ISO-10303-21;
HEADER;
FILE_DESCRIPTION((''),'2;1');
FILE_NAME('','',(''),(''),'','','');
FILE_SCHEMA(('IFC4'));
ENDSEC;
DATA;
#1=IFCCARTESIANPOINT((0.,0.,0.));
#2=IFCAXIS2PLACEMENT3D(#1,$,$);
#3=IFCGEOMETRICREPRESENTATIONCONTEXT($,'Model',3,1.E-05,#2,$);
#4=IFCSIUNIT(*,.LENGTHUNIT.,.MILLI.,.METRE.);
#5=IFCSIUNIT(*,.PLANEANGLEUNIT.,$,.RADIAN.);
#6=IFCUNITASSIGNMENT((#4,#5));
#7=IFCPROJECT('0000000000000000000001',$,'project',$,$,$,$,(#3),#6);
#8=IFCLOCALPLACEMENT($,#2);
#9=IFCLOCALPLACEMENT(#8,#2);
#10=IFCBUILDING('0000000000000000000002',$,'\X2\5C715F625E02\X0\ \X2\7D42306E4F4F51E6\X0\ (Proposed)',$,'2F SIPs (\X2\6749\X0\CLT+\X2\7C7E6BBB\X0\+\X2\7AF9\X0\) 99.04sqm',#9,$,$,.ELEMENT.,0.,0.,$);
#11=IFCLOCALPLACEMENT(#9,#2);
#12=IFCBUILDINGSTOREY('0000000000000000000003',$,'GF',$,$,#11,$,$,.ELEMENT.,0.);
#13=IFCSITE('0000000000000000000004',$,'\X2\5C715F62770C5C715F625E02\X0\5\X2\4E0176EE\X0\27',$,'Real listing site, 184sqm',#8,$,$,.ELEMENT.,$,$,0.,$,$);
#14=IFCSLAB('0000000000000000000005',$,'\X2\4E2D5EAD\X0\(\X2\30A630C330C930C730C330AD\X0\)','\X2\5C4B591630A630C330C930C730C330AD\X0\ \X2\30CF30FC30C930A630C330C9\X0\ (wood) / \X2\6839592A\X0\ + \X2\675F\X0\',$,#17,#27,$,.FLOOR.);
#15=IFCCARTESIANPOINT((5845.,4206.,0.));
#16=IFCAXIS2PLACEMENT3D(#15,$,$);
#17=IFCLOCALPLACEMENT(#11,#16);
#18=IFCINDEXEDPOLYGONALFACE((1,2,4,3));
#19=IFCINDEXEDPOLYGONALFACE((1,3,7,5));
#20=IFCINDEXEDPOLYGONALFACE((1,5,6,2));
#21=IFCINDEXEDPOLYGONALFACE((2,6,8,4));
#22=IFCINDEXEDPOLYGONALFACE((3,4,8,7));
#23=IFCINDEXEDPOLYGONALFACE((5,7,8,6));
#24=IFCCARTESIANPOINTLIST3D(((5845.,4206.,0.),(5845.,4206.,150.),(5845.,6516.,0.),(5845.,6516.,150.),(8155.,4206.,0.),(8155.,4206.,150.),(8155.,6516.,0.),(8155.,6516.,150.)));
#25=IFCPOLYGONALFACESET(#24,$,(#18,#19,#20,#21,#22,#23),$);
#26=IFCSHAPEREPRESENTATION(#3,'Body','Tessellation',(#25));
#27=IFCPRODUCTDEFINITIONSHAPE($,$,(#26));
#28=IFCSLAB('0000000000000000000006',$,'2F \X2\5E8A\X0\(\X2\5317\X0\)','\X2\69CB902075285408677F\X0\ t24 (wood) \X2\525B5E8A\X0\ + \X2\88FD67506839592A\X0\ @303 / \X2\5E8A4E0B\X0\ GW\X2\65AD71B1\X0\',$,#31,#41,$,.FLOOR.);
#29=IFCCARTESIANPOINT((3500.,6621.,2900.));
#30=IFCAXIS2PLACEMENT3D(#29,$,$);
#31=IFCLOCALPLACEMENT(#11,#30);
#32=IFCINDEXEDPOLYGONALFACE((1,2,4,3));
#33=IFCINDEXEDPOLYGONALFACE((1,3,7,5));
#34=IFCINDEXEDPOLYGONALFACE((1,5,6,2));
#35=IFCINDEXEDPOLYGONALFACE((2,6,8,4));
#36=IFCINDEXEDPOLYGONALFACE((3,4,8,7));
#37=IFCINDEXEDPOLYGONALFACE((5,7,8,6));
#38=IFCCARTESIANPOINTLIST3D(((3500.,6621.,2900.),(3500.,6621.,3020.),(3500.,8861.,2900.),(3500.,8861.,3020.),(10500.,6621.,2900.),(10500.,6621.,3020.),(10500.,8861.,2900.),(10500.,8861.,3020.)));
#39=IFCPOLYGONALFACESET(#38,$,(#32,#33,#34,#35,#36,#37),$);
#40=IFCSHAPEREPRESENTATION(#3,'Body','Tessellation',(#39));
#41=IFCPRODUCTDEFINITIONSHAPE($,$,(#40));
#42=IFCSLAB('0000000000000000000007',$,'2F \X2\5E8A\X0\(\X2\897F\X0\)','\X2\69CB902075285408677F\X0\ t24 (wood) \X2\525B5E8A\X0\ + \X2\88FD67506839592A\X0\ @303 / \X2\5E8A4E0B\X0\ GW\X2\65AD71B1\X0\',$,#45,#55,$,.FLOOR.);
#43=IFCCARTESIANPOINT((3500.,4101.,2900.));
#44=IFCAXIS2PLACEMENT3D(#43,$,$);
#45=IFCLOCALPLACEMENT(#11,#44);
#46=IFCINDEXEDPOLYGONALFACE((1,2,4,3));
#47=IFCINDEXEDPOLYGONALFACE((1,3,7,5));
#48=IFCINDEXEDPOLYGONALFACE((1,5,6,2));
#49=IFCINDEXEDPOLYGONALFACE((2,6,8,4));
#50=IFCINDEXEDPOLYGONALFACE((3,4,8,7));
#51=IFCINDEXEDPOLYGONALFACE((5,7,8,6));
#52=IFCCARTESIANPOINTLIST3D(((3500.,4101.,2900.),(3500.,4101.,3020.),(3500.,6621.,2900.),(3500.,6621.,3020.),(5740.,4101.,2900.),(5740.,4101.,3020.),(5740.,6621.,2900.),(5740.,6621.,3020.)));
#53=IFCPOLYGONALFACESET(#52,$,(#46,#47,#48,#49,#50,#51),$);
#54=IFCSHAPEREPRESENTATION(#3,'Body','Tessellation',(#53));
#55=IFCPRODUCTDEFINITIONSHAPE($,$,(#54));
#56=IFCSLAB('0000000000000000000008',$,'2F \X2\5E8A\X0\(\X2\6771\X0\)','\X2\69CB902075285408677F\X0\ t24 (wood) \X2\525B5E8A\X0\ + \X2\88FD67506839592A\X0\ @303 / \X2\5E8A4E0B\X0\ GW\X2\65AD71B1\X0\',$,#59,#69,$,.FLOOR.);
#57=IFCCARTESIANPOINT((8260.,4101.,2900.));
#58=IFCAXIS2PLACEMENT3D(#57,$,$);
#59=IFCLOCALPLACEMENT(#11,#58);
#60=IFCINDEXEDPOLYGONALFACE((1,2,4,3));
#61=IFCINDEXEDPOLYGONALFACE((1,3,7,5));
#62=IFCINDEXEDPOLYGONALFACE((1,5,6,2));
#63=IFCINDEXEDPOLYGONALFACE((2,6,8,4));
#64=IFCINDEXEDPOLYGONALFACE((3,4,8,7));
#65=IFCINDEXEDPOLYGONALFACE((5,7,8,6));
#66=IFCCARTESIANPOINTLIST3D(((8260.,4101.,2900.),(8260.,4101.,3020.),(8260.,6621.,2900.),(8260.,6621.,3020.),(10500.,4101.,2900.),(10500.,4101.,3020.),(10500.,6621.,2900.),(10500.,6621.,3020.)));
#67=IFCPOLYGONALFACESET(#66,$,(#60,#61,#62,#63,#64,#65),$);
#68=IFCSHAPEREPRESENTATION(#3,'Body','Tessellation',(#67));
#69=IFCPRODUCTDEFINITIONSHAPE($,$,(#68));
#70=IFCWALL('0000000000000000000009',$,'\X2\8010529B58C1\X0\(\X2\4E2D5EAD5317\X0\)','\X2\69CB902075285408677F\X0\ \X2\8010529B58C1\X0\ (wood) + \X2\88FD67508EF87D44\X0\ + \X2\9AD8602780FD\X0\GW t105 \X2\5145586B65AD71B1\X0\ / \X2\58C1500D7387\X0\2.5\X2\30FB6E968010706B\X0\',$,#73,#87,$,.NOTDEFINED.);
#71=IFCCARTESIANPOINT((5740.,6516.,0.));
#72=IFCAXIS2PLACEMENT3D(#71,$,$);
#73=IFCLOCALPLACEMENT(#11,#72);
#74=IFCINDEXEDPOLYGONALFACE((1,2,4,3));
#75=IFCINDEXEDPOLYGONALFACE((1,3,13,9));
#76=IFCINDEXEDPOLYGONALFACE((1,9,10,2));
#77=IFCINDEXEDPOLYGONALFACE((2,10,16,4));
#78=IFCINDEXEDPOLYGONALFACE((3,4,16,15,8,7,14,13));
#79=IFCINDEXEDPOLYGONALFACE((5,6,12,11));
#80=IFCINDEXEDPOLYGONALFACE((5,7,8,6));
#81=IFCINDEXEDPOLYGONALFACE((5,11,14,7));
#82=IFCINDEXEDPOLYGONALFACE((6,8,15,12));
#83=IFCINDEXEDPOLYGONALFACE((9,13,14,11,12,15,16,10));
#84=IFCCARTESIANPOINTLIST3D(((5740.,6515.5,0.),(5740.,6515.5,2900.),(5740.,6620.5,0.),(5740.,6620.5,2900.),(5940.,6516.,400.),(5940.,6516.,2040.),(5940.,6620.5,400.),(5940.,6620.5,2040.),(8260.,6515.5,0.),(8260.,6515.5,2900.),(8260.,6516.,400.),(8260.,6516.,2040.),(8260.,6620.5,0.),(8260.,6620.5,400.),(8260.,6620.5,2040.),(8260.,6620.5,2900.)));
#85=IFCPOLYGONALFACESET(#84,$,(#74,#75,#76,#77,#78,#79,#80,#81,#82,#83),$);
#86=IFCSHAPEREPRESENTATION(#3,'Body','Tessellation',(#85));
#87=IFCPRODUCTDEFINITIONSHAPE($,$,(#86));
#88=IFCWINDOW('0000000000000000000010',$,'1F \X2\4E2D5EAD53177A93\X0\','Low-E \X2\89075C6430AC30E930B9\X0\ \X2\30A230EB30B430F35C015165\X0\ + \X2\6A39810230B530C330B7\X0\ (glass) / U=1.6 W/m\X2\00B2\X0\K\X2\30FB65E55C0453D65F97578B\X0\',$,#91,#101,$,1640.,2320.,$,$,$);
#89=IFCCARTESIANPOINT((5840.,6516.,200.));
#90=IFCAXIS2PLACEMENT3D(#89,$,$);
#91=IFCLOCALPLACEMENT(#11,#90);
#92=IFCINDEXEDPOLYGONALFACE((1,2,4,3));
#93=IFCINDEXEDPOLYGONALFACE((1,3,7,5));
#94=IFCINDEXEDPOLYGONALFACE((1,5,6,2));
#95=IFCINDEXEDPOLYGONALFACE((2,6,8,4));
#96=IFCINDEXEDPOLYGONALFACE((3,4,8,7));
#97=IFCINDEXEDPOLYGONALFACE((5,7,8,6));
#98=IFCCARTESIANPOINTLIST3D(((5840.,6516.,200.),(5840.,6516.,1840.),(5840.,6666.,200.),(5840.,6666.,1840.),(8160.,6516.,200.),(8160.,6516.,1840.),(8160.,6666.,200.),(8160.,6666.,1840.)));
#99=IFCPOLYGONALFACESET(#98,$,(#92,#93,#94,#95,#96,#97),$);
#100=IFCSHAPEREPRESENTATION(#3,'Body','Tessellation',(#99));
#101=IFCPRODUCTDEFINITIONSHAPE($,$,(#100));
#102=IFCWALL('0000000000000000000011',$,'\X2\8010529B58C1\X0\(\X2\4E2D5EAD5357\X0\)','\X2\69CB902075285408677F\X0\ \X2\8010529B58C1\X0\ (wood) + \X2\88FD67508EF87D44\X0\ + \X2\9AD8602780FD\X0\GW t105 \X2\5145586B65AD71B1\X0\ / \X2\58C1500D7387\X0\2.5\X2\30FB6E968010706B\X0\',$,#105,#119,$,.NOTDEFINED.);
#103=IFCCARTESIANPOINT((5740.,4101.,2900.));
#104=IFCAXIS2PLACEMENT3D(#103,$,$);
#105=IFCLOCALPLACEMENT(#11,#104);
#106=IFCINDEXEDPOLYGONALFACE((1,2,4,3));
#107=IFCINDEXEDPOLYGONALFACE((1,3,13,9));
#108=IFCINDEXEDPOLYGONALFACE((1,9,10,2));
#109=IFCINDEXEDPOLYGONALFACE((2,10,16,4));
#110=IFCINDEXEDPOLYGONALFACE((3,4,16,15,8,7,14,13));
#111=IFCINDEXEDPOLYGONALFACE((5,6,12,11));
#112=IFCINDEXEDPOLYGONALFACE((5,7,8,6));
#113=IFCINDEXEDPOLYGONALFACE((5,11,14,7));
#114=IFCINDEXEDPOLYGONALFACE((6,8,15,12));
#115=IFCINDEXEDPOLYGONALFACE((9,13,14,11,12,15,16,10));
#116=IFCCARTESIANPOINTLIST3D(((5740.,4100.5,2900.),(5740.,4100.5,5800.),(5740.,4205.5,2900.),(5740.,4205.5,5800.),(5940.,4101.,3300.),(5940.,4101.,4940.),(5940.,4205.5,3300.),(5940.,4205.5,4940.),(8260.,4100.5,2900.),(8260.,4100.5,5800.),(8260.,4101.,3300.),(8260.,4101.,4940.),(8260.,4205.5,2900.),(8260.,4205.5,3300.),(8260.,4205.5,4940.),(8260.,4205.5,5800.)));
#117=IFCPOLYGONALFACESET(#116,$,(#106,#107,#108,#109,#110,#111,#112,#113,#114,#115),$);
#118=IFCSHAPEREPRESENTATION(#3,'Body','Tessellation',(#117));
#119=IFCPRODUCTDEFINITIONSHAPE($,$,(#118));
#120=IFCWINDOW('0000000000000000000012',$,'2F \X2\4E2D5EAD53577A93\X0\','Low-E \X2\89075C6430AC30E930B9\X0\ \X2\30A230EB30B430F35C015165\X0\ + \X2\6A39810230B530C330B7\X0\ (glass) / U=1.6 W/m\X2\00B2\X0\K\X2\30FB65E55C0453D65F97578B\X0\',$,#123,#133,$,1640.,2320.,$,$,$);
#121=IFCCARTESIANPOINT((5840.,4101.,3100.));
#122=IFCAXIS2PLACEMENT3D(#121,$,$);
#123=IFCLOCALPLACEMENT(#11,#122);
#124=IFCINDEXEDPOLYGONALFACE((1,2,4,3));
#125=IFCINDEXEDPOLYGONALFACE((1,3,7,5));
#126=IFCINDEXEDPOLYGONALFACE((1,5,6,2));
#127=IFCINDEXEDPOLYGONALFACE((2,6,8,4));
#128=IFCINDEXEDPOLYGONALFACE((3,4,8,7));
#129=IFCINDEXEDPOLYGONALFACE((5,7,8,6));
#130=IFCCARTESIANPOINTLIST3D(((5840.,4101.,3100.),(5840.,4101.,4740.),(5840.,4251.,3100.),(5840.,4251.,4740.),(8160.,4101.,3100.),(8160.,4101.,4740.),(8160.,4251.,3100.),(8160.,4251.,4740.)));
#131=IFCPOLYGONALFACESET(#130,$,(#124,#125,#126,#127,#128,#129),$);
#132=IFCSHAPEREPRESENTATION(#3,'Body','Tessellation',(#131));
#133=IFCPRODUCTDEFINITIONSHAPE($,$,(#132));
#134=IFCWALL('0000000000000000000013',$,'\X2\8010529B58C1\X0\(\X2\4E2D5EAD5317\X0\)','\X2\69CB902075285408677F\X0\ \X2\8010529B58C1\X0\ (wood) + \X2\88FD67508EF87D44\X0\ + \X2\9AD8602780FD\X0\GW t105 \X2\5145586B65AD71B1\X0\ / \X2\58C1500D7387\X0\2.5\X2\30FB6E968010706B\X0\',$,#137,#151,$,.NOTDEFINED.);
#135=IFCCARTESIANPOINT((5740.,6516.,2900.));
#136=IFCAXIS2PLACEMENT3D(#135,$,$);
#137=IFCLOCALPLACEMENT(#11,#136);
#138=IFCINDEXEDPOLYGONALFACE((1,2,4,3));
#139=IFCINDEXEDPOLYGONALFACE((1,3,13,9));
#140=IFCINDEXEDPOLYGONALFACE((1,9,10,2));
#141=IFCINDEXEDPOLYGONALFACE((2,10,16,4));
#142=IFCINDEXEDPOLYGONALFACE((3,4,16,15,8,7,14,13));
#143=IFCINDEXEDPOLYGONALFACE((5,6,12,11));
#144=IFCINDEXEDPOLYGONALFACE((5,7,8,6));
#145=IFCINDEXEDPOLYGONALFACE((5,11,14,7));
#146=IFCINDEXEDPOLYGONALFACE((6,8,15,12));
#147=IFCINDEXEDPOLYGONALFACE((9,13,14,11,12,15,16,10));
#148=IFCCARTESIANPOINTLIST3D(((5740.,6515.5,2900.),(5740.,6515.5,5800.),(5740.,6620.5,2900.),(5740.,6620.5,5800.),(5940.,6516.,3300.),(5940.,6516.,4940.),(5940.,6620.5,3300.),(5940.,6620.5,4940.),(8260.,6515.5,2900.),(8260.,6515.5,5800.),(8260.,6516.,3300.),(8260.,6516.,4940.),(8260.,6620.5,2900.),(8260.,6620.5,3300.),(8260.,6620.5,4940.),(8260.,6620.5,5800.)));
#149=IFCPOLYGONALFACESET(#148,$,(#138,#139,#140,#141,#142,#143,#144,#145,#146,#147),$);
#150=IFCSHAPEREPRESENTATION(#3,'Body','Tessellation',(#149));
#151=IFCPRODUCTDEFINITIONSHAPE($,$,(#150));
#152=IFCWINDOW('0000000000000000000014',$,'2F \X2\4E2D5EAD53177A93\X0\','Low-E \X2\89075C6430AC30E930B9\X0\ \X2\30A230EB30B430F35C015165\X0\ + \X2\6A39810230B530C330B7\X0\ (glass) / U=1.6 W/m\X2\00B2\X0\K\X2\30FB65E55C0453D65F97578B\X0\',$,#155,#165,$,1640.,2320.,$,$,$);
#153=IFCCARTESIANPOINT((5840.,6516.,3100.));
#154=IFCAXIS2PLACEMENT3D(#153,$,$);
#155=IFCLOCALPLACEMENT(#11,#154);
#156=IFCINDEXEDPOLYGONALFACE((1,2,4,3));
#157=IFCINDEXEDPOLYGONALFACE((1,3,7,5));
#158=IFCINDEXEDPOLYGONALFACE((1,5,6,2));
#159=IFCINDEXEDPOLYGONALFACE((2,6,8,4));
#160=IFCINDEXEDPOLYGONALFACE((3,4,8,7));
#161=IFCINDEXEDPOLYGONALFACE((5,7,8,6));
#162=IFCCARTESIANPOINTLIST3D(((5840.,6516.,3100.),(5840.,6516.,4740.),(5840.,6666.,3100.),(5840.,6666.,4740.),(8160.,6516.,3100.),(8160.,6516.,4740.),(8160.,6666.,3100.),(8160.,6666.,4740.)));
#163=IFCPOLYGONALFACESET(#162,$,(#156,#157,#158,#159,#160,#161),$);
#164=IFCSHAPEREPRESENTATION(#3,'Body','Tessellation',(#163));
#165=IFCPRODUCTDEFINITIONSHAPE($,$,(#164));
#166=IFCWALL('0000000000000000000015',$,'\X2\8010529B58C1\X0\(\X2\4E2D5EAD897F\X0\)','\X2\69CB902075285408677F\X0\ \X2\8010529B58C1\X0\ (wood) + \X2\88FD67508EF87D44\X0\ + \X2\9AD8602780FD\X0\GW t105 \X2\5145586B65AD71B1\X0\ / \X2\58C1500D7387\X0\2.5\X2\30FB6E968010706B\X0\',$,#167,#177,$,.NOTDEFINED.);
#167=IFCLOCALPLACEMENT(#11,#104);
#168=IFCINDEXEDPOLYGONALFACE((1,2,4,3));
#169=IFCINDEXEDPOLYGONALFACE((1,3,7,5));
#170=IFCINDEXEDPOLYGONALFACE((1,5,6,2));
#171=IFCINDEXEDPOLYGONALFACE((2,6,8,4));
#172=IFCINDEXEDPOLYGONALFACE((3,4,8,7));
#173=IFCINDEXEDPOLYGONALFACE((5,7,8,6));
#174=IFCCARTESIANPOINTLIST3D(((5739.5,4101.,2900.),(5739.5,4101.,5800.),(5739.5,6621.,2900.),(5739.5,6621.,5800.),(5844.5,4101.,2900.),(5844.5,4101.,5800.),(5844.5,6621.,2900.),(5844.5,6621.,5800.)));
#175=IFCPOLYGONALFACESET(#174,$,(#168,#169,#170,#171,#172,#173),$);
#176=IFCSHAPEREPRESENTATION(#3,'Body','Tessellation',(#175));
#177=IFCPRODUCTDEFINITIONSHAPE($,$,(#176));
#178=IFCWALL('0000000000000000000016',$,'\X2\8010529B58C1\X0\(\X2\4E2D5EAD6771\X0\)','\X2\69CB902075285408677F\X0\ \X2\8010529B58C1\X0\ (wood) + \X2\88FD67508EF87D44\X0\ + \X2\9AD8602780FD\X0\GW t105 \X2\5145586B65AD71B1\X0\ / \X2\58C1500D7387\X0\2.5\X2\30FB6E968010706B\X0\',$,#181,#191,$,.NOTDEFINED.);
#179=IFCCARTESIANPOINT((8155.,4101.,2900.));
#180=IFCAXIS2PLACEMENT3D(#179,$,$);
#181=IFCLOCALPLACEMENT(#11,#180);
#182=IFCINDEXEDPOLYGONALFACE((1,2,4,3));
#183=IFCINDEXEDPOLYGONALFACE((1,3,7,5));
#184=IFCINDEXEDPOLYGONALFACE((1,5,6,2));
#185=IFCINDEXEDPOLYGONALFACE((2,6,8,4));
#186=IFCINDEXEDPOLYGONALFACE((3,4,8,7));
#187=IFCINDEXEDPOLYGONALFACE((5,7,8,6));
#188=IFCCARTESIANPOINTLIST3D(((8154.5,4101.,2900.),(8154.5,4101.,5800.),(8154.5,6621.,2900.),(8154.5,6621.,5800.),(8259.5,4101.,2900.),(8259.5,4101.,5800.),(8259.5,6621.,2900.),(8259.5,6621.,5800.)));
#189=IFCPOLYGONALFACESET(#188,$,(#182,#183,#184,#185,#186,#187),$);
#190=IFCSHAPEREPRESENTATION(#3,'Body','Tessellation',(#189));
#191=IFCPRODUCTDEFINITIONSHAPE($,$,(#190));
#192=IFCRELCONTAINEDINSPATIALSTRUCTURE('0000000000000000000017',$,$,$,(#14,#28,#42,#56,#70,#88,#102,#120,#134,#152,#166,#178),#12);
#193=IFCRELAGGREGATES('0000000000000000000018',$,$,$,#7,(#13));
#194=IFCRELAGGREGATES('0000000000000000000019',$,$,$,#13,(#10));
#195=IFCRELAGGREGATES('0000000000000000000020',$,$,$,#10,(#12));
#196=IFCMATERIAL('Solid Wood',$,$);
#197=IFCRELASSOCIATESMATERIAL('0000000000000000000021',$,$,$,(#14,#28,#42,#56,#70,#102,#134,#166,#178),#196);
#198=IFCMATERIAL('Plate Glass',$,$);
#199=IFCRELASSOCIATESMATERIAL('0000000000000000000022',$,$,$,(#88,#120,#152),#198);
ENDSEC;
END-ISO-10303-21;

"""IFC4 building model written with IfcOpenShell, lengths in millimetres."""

from ifc_helpers import new_model, si_unit, frame, frame_2d, origin, place, context, project, spatial, rectangle, extrude, material, element, fill, save


model = new_model("IFC4")

# Units and contexts
model_context = context("Model", 3, precision=1e-05, world=origin())
ifc_project = project(units=[si_unit("LENGTHUNIT", "METRE", prefix="MILLI"), si_unit("PLANEANGLEUNIT", "RADIAN")], contexts=[model_context])

# Site, building, storey
site_placement = place(None, origin())
site = spatial("IfcSite", under=ifc_project, at=site_placement, Name="山形県山形市5丁目27", ObjectType="Real listing site, 184sqm", CompositionType="ELEMENT", RefElevation=0.0)
building_placement = place(site_placement, origin())
building = spatial("IfcBuilding", under=site, at=building_placement, Name="山形市 終の住処 (Proposed)", ObjectType="2F SIPs (杉CLT+籾殻+竹) 99.04sqm", CompositionType="ELEMENT", ElevationOfRefHeight=0.0, ElevationOfTerrain=0.0)
storey_placement = place(building_placement, origin())
storey = spatial("IfcBuildingStorey", under=building, at=storey_placement, Name="GF", CompositionType="ELEMENT", Elevation=0.0)

# Slabs
ifc_material_1 = material(Name="Solid Wood")
slab_1_placement = place(storey_placement, frame((5845.0, 4206.0, 0.0)))
element("IfcSlab", 1, at=slab_1_placement, inside=storey, material=ifc_material_1, Name="中庭(ウッドデッキ)", Description="屋外ウッドデッキ ハードウッド (wood) / 根太 + 束", PredefinedType="FLOOR", context=model_context, shape_type="SweptSolid", body=[
    extrude(rectangle(XDim=2310.0, YDim=2310.0, at=frame_2d((1155.0, 1155.0))), frame((5845.0, 4206.0, 0.0)), (0.0, 0.0, 1.0), 150.0),
])
slab_2_placement = place(storey_placement, frame((3500.0, 6621.0, 2900.0)))
element("IfcSlab", 2, at=slab_2_placement, inside=storey, material=ifc_material_1, Name="2F 床(北)", Description="構造用合板 t24 (wood) 剛床 + 製材根太 @303 / 床下 GW断熱", PredefinedType="FLOOR", context=model_context, shape_type="SweptSolid", body=[
    extrude(rectangle(XDim=7000.0, YDim=2240.0, at=frame_2d((3500.0, 1120.0))), frame((3500.0, 6621.0, 2900.0)), (0.0, 0.0, 1.0), 120.0),
])
slab_3_placement = place(storey_placement, frame((3500.0, 4101.0, 2900.0)))
element("IfcSlab", 3, at=slab_3_placement, inside=storey, material=ifc_material_1, Name="2F 床(西)", Description="構造用合板 t24 (wood) 剛床 + 製材根太 @303 / 床下 GW断熱", PredefinedType="FLOOR", context=model_context, shape_type="SweptSolid", body=[
    extrude(rectangle(XDim=2240.0, YDim=2520.0, at=frame_2d((1120.0, 1260.0))), frame((3500.0, 4101.0, 2900.0)), (0.0, 0.0, 1.0), 120.0),
])
slab_4_placement = place(storey_placement, frame((8260.0, 4101.0, 2900.0)))
element("IfcSlab", 4, at=slab_4_placement, inside=storey, material=ifc_material_1, Name="2F 床(東)", Description="構造用合板 t24 (wood) 剛床 + 製材根太 @303 / 床下 GW断熱", PredefinedType="FLOOR", context=model_context, shape_type="SweptSolid", body=[
    extrude(rectangle(XDim=2240.0, YDim=2520.0, at=frame_2d((1120.0, 1260.0))), frame((8260.0, 4101.0, 2900.0)), (0.0, 0.0, 1.0), 120.0),
])

# Wall, opening, window
wall_1_placement = place(storey_placement, frame((5740.0, 6516.0, 0.0)))
wall_1 = element("IfcWall", 5, at=wall_1_placement, inside=storey, material=ifc_material_1, Name="耐力壁(中庭北)", Description="構造用合板 耐力壁 (wood) + 製材軸組 + 高性能GW t105 充填断熱 / 壁倍率2.5・準耐火", PredefinedType="NOTDEFINED", context=model_context, shape_type="SweptSolid", body=[
    extrude(rectangle(XDim=2520.0, YDim=105.0, at=frame_2d((1260.0, 52.0))), frame((5740.0, 6516.0, 0.0)), (0.0, 0.0, 1.0), 2900.0),
])
opening_1_placement = place(storey_placement, frame((5840.0, 6516.0, 200.0)))
opening_1 = element("IfcOpeningElement", 6, at=opening_1_placement, cuts=wall_1, PredefinedType="NOTDEFINED", context=model_context, shape_type="SweptSolid", body=[
    extrude(rectangle(XDim=2320.0, YDim=150.0, at=frame_2d((1160.0, 75.0))), frame((5840.0, 6516.0, 200.0)), (0.0, 0.0, 1.0), 1640.0),
])
ifc_material_2 = material(Name="Plate Glass")
window_1_placement = place(storey_placement, frame((5840.0, 6516.0, 200.0)))
window_1 = element("IfcWindow", 7, at=window_1_placement, inside=storey, material=ifc_material_2, Name="1F 中庭北窓", Description="Low-E 複層ガラス アルゴン封入 + 樹脂サッシ (glass) / U=1.6 W/m²K・日射取得型", OverallHeight=1640.0, OverallWidth=2320.0, context=model_context, shape_type="SweptSolid", body=[
    extrude(rectangle(XDim=2320.0, YDim=150.0, at=frame_2d((1160.0, 75.0))), frame((5840.0, 6516.0, 200.0)), (0.0, 0.0, 1.0), 1640.0),
])
fill(opening_1, window_1)

# Walls, openings, windows
wall_2_placement = place(storey_placement, frame((5740.0, 4101.0, 2900.0)))
wall_2 = element("IfcWall", 8, at=wall_2_placement, inside=storey, material=ifc_material_1, Name="耐力壁(中庭南)", Description="構造用合板 耐力壁 (wood) + 製材軸組 + 高性能GW t105 充填断熱 / 壁倍率2.5・準耐火", PredefinedType="NOTDEFINED", context=model_context, shape_type="SweptSolid", body=[
    extrude(rectangle(XDim=2520.0, YDim=105.0, at=frame_2d((1260.0, 52.0))), frame((5740.0, 4101.0, 2900.0)), (0.0, 0.0, 1.0), 2900.0),
])
opening_2_placement = place(storey_placement, frame((5840.0, 4101.0, 3100.0)))
opening_2 = element("IfcOpeningElement", 9, at=opening_2_placement, cuts=wall_2, PredefinedType="NOTDEFINED", context=model_context, shape_type="SweptSolid", body=[
    extrude(rectangle(XDim=2320.0, YDim=150.0, at=frame_2d((1160.0, 75.0))), frame((5840.0, 4101.0, 3100.0)), (0.0, 0.0, 1.0), 1640.0),
])
window_2_placement = place(storey_placement, frame((5840.0, 4101.0, 3100.0)))
window_2 = element("IfcWindow", 10, at=window_2_placement, inside=storey, material=ifc_material_2, Name="2F 中庭南窓", Description="Low-E 複層ガラス アルゴン封入 + 樹脂サッシ (glass) / U=1.6 W/m²K・日射取得型", OverallHeight=1640.0, OverallWidth=2320.0, context=model_context, shape_type="SweptSolid", body=[
    extrude(rectangle(XDim=2320.0, YDim=150.0, at=frame_2d((1160.0, 75.0))), frame((5840.0, 4101.0, 3100.0)), (0.0, 0.0, 1.0), 1640.0),
])
fill(opening_2, window_2)
wall_3_placement = place(storey_placement, frame((5740.0, 6516.0, 2900.0)))
wall_3 = element("IfcWall", 11, at=wall_3_placement, inside=storey, material=ifc_material_1, Name="耐力壁(中庭北)", Description="構造用合板 耐力壁 (wood) + 製材軸組 + 高性能GW t105 充填断熱 / 壁倍率2.5・準耐火", PredefinedType="NOTDEFINED", context=model_context, shape_type="SweptSolid", body=[
    extrude(rectangle(XDim=2520.0, YDim=105.0, at=frame_2d((1260.0, 52.0))), frame((5740.0, 6516.0, 2900.0)), (0.0, 0.0, 1.0), 2900.0),
])
opening_3_placement = place(storey_placement, frame((5840.0, 6516.0, 3100.0)))
opening_3 = element("IfcOpeningElement", 12, at=opening_3_placement, cuts=wall_3, PredefinedType="NOTDEFINED", context=model_context, shape_type="SweptSolid", body=[
    extrude(rectangle(XDim=2320.0, YDim=150.0, at=frame_2d((1160.0, 75.0))), frame((5840.0, 6516.0, 3100.0)), (0.0, 0.0, 1.0), 1640.0),
])
window_3_placement = place(storey_placement, frame((5840.0, 6516.0, 3100.0)))
window_3 = element("IfcWindow", 13, at=window_3_placement, inside=storey, material=ifc_material_2, Name="2F 中庭北窓", Description="Low-E 複層ガラス アルゴン封入 + 樹脂サッシ (glass) / U=1.6 W/m²K・日射取得型", OverallHeight=1640.0, OverallWidth=2320.0, context=model_context, shape_type="SweptSolid", body=[
    extrude(rectangle(XDim=2320.0, YDim=150.0, at=frame_2d((1160.0, 75.0))), frame((5840.0, 6516.0, 3100.0)), (0.0, 0.0, 1.0), 1640.0),
])
fill(opening_3, window_3)

# Walls
wall_4_placement = place(storey_placement, frame((5740.0, 4101.0, 2900.0)))
element("IfcWall", 14, at=wall_4_placement, inside=storey, material=ifc_material_1, Name="耐力壁(中庭西)", Description="構造用合板 耐力壁 (wood) + 製材軸組 + 高性能GW t105 充填断熱 / 壁倍率2.5・準耐火", PredefinedType="NOTDEFINED", context=model_context, shape_type="SweptSolid", body=[
    extrude(rectangle(XDim=105.0, YDim=2520.0, at=frame_2d((52.0, 1260.0))), frame((5740.0, 4101.0, 2900.0)), (0.0, 0.0, 1.0), 2900.0),
])
wall_5_placement = place(storey_placement, frame((8155.0, 4101.0, 2900.0)))
element("IfcWall", 15, at=wall_5_placement, inside=storey, material=ifc_material_1, Name="耐力壁(中庭東)", Description="構造用合板 耐力壁 (wood) + 製材軸組 + 高性能GW t105 充填断熱 / 壁倍率2.5・準耐火", PredefinedType="NOTDEFINED", context=model_context, shape_type="SweptSolid", body=[
    extrude(rectangle(XDim=105.0, YDim=2520.0, at=frame_2d((52.0, 1260.0))), frame((8155.0, 4101.0, 2900.0)), (0.0, 0.0, 1.0), 2900.0),
])

save(model, "model.ifc")
